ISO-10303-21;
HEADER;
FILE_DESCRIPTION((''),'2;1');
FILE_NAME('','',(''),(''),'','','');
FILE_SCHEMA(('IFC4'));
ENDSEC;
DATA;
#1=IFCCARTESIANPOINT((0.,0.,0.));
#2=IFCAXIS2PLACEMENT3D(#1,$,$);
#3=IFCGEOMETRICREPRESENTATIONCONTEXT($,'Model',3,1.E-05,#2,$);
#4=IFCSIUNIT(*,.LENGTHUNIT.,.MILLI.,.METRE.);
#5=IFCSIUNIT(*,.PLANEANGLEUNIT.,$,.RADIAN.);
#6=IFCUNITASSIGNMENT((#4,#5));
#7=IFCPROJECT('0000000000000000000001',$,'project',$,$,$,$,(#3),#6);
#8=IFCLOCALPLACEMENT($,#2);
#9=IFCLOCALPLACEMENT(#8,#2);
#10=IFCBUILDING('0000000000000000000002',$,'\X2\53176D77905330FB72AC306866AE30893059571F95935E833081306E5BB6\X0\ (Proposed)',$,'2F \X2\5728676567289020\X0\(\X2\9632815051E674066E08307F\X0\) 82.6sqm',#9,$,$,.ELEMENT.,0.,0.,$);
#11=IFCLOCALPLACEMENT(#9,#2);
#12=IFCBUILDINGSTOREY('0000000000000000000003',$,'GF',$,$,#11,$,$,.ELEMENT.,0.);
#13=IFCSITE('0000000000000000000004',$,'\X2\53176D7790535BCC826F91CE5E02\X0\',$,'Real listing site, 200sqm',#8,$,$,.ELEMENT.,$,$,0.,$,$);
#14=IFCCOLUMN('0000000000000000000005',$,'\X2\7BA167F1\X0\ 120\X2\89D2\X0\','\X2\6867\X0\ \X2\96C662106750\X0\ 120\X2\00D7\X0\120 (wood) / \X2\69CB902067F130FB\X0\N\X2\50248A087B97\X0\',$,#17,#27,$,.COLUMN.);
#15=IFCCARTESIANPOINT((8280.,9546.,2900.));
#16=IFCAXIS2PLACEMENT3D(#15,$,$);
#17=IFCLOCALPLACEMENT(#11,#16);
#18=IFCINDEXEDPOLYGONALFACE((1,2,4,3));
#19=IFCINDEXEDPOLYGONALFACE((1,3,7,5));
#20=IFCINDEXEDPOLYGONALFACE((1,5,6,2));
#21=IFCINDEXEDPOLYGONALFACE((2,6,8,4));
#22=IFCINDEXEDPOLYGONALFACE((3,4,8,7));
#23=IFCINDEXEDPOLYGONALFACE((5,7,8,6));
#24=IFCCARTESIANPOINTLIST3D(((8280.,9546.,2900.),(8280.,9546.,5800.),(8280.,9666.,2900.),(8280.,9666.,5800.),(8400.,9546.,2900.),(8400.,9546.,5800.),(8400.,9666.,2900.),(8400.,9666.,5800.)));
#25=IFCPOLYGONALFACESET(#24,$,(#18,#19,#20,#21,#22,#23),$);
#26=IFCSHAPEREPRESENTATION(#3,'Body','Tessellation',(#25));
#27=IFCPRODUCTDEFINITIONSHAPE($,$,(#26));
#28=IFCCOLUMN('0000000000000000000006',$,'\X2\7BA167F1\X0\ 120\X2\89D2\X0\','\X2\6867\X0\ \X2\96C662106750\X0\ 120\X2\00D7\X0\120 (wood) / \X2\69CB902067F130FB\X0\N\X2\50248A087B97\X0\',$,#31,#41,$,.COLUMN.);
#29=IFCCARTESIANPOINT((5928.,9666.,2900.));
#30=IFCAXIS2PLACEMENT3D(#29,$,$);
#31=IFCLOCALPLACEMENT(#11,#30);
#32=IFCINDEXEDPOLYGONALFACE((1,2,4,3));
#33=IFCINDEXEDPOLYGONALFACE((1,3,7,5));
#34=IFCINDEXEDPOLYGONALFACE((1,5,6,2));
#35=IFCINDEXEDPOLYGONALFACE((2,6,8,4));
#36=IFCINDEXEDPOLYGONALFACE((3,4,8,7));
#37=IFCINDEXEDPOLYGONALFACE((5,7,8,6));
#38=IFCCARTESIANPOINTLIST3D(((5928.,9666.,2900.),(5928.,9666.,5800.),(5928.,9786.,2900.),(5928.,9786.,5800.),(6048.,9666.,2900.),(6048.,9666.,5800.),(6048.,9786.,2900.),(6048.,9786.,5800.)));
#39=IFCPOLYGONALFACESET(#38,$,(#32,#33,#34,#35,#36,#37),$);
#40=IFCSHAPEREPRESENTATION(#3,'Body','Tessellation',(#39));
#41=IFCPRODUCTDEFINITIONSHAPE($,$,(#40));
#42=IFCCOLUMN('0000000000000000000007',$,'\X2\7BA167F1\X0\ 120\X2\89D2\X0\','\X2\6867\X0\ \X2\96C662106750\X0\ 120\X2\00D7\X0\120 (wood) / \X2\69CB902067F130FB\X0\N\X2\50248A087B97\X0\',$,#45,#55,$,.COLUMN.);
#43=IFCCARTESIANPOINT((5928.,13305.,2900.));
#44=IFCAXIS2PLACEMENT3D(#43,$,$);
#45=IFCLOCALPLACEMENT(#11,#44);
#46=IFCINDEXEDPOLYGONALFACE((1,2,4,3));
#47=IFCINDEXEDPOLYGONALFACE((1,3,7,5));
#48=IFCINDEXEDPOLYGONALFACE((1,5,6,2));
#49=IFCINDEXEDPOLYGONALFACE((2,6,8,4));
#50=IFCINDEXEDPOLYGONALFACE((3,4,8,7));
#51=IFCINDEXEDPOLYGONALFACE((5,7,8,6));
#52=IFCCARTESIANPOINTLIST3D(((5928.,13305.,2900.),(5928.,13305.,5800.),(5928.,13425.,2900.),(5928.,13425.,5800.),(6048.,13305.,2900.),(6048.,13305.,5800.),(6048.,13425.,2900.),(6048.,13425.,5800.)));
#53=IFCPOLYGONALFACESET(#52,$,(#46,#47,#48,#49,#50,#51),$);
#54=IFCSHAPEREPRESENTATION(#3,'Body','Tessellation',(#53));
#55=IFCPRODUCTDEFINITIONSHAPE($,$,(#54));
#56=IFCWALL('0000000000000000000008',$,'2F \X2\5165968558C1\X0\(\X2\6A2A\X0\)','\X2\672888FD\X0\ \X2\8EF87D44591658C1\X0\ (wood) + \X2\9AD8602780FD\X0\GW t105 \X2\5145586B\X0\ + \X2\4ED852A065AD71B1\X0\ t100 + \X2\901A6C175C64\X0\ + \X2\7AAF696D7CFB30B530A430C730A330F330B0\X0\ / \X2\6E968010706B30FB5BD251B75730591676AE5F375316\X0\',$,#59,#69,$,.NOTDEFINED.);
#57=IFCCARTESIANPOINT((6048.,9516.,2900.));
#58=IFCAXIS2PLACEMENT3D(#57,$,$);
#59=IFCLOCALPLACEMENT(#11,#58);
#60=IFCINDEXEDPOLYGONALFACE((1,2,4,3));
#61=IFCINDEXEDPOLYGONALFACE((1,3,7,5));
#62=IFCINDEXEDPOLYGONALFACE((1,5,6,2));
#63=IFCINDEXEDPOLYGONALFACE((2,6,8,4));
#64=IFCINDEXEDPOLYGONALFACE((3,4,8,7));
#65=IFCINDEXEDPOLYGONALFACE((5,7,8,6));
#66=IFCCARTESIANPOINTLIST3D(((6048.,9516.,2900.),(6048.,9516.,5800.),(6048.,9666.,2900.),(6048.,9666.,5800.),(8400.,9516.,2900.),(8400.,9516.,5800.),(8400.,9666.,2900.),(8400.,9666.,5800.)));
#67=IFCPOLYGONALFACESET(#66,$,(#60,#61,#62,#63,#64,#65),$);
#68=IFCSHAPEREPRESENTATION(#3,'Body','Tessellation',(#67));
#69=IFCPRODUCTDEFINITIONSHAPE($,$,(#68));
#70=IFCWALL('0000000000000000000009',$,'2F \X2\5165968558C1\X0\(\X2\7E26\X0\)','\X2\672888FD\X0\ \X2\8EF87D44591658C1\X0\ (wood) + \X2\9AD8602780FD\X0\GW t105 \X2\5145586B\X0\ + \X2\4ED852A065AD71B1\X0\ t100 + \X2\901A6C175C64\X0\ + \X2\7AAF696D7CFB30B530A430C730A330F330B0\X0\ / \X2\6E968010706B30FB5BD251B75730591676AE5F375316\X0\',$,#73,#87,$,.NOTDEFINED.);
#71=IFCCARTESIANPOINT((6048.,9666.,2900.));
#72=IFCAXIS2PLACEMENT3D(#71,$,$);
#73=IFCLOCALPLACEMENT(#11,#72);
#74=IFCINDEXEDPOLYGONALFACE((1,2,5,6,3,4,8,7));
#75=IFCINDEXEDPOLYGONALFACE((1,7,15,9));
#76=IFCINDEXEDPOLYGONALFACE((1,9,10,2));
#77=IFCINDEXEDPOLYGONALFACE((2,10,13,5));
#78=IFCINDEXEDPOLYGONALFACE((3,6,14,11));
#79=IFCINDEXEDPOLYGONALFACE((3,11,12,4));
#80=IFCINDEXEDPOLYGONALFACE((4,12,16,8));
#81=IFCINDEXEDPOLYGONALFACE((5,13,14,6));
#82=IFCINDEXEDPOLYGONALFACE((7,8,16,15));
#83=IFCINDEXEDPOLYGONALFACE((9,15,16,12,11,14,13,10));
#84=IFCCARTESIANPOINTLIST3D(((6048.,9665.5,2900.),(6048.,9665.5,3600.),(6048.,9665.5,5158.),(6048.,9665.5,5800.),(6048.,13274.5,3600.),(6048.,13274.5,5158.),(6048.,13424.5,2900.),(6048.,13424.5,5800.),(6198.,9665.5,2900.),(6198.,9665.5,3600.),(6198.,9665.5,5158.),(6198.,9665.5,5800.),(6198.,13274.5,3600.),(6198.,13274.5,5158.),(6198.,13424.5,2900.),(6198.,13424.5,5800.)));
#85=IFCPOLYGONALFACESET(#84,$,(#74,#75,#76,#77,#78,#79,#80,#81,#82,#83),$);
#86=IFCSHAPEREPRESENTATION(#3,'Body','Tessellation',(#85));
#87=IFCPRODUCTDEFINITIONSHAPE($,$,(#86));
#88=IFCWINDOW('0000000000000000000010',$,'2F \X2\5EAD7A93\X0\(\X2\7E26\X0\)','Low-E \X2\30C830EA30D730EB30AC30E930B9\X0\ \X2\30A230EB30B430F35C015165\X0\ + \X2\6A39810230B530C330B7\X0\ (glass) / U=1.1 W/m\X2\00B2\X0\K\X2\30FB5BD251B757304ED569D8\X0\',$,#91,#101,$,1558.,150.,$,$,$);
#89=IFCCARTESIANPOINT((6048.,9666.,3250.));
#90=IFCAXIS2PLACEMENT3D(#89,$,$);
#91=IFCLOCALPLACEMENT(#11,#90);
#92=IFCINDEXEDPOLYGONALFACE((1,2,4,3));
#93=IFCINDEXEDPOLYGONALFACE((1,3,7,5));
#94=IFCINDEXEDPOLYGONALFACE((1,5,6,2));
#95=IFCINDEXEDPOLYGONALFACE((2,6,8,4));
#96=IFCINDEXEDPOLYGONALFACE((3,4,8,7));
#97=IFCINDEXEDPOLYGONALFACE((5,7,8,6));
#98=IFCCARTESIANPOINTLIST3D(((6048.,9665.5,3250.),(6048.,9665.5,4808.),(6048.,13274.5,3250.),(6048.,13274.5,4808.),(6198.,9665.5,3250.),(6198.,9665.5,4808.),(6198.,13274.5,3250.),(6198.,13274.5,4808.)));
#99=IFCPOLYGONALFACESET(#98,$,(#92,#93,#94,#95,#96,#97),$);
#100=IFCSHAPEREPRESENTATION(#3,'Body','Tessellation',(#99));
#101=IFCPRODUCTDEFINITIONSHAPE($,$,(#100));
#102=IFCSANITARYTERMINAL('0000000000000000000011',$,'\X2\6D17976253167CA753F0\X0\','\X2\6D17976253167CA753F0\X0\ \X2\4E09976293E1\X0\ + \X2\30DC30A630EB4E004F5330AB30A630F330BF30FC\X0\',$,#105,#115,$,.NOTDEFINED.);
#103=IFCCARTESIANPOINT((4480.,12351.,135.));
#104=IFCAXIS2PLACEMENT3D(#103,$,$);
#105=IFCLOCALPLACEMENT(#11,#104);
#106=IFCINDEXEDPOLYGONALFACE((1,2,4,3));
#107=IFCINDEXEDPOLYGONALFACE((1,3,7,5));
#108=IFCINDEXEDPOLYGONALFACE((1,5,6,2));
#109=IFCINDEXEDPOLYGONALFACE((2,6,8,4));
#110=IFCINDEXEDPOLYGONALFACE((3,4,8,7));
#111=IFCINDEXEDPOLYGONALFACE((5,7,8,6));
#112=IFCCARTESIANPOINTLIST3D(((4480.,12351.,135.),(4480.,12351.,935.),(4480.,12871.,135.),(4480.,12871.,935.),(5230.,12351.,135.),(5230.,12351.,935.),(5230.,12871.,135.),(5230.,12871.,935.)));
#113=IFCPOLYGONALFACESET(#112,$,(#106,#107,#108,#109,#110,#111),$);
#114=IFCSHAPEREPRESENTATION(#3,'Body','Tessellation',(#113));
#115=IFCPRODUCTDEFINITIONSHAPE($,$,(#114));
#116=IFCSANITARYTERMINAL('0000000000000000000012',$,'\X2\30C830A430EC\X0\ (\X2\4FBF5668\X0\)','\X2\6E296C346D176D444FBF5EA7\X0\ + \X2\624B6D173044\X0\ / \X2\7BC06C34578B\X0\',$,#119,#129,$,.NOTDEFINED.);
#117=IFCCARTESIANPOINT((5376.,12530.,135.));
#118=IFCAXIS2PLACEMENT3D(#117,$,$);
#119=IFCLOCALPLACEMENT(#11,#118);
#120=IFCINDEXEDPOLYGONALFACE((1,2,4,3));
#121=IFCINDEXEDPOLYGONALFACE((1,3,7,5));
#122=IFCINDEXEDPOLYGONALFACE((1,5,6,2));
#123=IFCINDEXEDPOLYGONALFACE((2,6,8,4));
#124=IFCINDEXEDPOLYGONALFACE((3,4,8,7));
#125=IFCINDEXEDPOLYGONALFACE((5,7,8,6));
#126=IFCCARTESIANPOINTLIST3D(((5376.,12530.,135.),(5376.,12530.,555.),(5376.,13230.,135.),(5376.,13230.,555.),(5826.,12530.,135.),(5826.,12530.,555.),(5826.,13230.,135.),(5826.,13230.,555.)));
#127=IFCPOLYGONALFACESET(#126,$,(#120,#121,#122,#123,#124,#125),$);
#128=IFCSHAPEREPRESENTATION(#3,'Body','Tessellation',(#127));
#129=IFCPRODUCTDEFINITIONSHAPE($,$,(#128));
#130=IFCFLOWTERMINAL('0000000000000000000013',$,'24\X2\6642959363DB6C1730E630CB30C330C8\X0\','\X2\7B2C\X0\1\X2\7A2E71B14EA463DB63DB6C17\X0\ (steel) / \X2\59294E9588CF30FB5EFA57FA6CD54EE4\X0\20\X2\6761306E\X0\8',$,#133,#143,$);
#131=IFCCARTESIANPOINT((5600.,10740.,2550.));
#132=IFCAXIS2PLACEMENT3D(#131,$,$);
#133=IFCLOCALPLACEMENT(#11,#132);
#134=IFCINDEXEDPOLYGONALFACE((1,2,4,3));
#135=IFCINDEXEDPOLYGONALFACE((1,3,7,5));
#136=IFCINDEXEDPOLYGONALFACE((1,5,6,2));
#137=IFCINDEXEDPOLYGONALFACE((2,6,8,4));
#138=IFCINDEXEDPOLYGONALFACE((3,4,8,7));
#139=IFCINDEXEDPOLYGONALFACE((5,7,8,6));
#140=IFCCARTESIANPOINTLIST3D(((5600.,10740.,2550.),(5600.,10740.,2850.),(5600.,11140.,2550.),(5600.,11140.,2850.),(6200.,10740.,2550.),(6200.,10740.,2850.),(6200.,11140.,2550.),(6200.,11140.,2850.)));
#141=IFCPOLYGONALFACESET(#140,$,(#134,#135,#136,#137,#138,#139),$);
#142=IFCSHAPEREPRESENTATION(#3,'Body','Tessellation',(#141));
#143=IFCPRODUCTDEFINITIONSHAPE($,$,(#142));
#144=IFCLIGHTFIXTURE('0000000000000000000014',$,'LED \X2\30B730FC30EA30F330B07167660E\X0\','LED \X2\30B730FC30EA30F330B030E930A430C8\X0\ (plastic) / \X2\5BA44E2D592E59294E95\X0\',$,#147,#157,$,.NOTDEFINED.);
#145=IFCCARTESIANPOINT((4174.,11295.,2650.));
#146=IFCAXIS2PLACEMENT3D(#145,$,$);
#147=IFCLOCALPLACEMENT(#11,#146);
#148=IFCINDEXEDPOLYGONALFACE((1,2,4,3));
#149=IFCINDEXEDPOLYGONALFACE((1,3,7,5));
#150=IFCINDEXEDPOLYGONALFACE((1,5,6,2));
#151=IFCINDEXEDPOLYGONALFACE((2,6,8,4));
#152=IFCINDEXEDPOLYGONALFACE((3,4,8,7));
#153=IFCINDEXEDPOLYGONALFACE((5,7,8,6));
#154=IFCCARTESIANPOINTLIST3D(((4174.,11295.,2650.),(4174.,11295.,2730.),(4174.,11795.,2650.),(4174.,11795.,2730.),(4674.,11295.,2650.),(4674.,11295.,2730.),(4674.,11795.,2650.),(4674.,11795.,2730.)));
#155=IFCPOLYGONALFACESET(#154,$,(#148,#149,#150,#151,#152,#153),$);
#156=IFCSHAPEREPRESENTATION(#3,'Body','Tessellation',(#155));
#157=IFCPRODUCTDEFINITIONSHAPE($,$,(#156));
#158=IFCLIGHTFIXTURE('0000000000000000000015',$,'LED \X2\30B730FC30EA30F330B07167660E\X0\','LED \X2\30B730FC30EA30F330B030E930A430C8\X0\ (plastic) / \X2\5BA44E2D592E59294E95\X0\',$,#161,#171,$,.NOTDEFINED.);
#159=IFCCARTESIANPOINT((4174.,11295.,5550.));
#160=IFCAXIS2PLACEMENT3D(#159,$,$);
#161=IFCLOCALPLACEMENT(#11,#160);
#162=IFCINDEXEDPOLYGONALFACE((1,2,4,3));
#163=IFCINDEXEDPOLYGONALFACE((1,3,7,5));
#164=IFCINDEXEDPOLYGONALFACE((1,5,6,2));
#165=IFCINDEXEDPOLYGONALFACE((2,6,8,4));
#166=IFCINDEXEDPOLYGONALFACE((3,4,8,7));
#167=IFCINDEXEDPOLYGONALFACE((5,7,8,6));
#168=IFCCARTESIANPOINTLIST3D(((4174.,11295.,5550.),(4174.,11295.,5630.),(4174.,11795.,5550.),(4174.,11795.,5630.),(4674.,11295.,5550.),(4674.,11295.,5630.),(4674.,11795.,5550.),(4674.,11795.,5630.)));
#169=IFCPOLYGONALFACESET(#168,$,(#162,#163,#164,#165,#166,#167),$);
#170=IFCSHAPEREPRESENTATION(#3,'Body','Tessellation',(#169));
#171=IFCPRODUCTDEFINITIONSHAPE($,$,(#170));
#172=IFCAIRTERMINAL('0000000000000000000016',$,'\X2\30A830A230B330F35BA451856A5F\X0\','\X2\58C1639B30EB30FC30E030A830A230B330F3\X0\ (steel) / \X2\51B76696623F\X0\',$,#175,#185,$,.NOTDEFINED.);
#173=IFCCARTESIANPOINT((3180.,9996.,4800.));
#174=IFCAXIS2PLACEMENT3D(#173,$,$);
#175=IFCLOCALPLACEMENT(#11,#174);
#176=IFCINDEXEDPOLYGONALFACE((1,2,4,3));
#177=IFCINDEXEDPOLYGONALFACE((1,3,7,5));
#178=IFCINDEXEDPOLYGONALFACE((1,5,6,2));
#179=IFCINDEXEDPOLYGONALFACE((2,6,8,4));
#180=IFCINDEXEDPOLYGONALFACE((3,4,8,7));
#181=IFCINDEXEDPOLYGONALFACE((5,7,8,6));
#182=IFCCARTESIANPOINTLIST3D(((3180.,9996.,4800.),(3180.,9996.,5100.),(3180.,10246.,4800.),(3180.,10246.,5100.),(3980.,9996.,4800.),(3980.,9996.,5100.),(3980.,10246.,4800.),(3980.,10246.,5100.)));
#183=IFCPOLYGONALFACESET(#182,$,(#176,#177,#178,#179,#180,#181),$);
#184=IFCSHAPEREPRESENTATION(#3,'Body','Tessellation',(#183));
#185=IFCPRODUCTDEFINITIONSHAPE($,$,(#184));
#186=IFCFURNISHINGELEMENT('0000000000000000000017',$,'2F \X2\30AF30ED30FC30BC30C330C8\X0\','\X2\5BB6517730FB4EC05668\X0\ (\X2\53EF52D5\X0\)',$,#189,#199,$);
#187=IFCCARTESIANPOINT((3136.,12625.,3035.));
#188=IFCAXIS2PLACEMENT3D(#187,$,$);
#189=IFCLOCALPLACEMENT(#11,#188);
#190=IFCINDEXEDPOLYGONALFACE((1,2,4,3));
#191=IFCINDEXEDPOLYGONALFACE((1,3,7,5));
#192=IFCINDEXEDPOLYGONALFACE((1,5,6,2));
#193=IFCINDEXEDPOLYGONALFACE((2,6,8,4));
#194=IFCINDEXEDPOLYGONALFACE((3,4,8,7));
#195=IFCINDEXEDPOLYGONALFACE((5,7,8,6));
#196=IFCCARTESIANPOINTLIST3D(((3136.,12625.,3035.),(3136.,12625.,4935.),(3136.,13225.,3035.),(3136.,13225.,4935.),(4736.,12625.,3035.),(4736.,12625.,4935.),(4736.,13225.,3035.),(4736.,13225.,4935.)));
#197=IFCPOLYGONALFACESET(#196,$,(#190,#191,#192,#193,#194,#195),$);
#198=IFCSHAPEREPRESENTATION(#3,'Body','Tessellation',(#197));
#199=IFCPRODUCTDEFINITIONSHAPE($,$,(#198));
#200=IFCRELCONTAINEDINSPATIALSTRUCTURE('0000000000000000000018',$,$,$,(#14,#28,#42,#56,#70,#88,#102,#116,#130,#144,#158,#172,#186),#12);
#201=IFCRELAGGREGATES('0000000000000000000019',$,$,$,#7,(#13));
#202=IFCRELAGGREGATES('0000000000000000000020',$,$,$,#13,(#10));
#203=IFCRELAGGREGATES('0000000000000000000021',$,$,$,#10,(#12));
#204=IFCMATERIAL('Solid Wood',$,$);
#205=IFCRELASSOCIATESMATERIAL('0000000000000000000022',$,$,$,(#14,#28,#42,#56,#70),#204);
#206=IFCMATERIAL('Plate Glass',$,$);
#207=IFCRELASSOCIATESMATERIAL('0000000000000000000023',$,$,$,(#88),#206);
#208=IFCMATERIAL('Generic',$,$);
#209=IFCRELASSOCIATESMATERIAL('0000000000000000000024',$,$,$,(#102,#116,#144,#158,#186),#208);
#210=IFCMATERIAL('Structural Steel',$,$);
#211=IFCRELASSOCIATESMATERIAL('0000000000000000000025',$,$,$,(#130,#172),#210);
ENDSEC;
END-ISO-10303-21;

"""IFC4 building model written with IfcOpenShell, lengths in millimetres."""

from ifc_helpers import new_model, si_unit, frame, frame_2d, origin, place, context, project, spatial, rectangle, extrude, material, element, fill, save


model = new_model("IFC4")

# Units and contexts
model_context = context("Model", 3, precision=1e-05, world=origin())
ifc_project = project(units=[si_unit("LENGTHUNIT", "METRE", prefix="MILLI"), si_unit("PLANEANGLEUNIT", "RADIAN")], contexts=[model_context])

# Site, building, storey
site_placement = place(None, origin())
site = spatial("IfcSite", under=ifc_project, at=site_placement, Name="北海道富良野市", ObjectType="Real listing site, 200sqm", CompositionType="ELEMENT", RefElevation=0.0)
building_placement = place(site_placement, origin())
building = spatial("IfcBuilding", under=site, at=building_placement, Name="北海道・犬と暮らす土間広めの家 (Proposed)", ObjectType="2F 在来木造(防腐処理済み) 82.6sqm", CompositionType="ELEMENT", ElevationOfRefHeight=0.0, ElevationOfTerrain=0.0)
storey_placement = place(building_placement, origin())
storey = spatial("IfcBuildingStorey", under=building, at=storey_placement, Name="GF", CompositionType="ELEMENT", Elevation=0.0)

# Columns
ifc_material_1 = material(Name="Solid Wood")
column_1_placement = place(storey_placement, frame((8280.0, 9546.0, 2900.0)))
element("IfcColumn", 1, at=column_1_placement, inside=storey, material=ifc_material_1, Name="管柱 120角", Description="桧 集成材 120×120 (wood) / 構造柱・N値計算", PredefinedType="COLUMN", context=model_context, shape_type="SweptSolid", body=[
    extrude(rectangle(XDim=120.0, YDim=120.0, at=frame_2d((60.0, 60.0))), frame((8280.0, 9546.0, 2900.0)), (0.0, 0.0, 1.0), 2900.0),
])
column_2_placement = place(storey_placement, frame((5928.0, 9666.0, 2900.0)))
element("IfcColumn", 2, at=column_2_placement, inside=storey, material=ifc_material_1, Name="管柱 120角", Description="桧 集成材 120×120 (wood) / 構造柱・N値計算", PredefinedType="COLUMN", context=model_context, shape_type="SweptSolid", body=[
    extrude(rectangle(XDim=120.0, YDim=120.0, at=frame_2d((60.0, 60.0))), frame((5928.0, 9666.0, 2900.0)), (0.0, 0.0, 1.0), 2900.0),
])
column_3_placement = place(storey_placement, frame((5928.0, 13305.0, 2900.0)))
element("IfcColumn", 3, at=column_3_placement, inside=storey, material=ifc_material_1, Name="管柱 120角", Description="桧 集成材 120×120 (wood) / 構造柱・N値計算", PredefinedType="COLUMN", context=model_context, shape_type="SweptSolid", body=[
    extrude(rectangle(XDim=120.0, YDim=120.0, at=frame_2d((60.0, 60.0))), frame((5928.0, 13305.0, 2900.0)), (0.0, 0.0, 1.0), 2900.0),
])

# Wall
wall_1_placement = place(storey_placement, frame((6048.0, 9516.0, 2900.0)))
element("IfcWall", 4, at=wall_1_placement, inside=storey, material=ifc_material_1, Name="2F 入隅壁(横)", Description="木製 軸組外壁 (wood) + 高性能GW t105 充填 + 付加断熱 t100 + 通気層 + 窯業系サイディング / 準耐火・寒冷地外皮強化", PredefinedType="NOTDEFINED", context=model_context, shape_type="SweptSolid", body=[
    extrude(rectangle(XDim=2352.0, YDim=150.0, at=frame_2d((1176.0, 75.0))), frame((6048.0, 9516.0, 2900.0)), (0.0, 0.0, 1.0), 2900.0),
])

# Wall, opening, window
wall_2_placement = place(storey_placement, frame((6048.0, 9666.0, 2900.0)))
wall_2 = element("IfcWall", 5, at=wall_2_placement, inside=storey, material=ifc_material_1, Name="2F 入隅壁(縦)", Description="木製 軸組外壁 (wood) + 高性能GW t105 充填 + 付加断熱 t100 + 通気層 + 窯業系サイディング / 準耐火・寒冷地外皮強化", PredefinedType="NOTDEFINED", context=model_context, shape_type="SweptSolid", body=[
    extrude(rectangle(XDim=150.0, YDim=3759.0, at=frame_2d((75.0, 1879.0))), frame((6048.0, 9666.0, 2900.0)), (0.0, 0.0, 1.0), 2900.0),
])
opening_placement = place(storey_placement, frame((6048.0, 9666.0, 3250.0)))
opening = element("IfcOpeningElement", 6, at=opening_placement, cuts=wall_2, PredefinedType="NOTDEFINED", context=model_context, shape_type="SweptSolid", body=[
    extrude(rectangle(XDim=150.0, YDim=3609.0, at=frame_2d((75.0, 1804.0))), frame((6048.0, 9666.0, 3250.0)), (0.0, 0.0, 1.0), 1558.0),
])
ifc_material_2 = material(Name="Plate Glass")
window_placement = place(storey_placement, frame((6048.0, 9666.0, 3250.0)))
window = element("IfcWindow", 7, at=window_placement, inside=storey, material=ifc_material_2, Name="2F 庭窓(縦)", Description="Low-E トリプルガラス アルゴン封入 + 樹脂サッシ (glass) / U=1.1 W/m²K・寒冷地仕様", OverallHeight=1558.0, OverallWidth=150.0, context=model_context, shape_type="SweptSolid", body=[
    extrude(rectangle(XDim=150.0, YDim=3609.0, at=frame_2d((75.0, 1804.0))), frame((6048.0, 9666.0, 3250.0)), (0.0, 0.0, 1.0), 1558.0),
])
fill(opening, window)

# Sanitary terminals
ifc_material_3 = material(Name="Generic")
sanitary_terminal_1_placement = place(storey_placement, frame((4480.0, 12351.0, 135.0)))
element("IfcSanitaryTerminal", 8, at=sanitary_terminal_1_placement, inside=storey, material=ifc_material_3, Name="洗面化粧台", Description="洗面化粧台 三面鏡 + ボウル一体カウンター", PredefinedType="NOTDEFINED", context=model_context, shape_type="SweptSolid", body=[
    extrude(rectangle(XDim=750.0, YDim=520.0, at=frame_2d((375.0, 260.0))), frame((4480.0, 12351.0, 135.0)), (0.0, 0.0, 1.0), 800.0),
])
sanitary_terminal_2_placement = place(storey_placement, frame((5376.0, 12530.0, 135.0)))
element("IfcSanitaryTerminal", 9, at=sanitary_terminal_2_placement, inside=storey, material=ifc_material_3, Name="トイレ (便器)", Description="温水洗浄便座 + 手洗い / 節水型", PredefinedType="NOTDEFINED", context=model_context, shape_type="SweptSolid", body=[
    extrude(rectangle(XDim=450.0, YDim=700.0, at=frame_2d((225.0, 350.0))), frame((5376.0, 12530.0, 135.0)), (0.0, 0.0, 1.0), 420.0),
])

# Flow terminal
ifc_material_4 = material(Name="Structural Steel")
flow_terminal_placement = place(storey_placement, frame((5600.0, 10740.0, 2550.0)))
element("IfcFlowTerminal", 10, at=flow_terminal_placement, inside=storey, material=ifc_material_4, Name="24時間換気ユニット", Description="第1種熱交換換気 (steel) / 天井裏・建基法令20条の8", context=model_context, shape_type="SweptSolid", body=[
    extrude(rectangle(XDim=600.0, YDim=400.0, at=frame_2d((300.0, 200.0))), frame((5600.0, 10740.0, 2550.0)), (0.0, 0.0, 1.0), 300.0),
])

# Light fixtures
light_fixture_1_placement = place(storey_placement, frame((4174.0, 11295.0, 2650.0)))
element("IfcLightFixture", 11, at=light_fixture_1_placement, inside=storey, material=ifc_material_3, Name="LED シーリング照明", Description="LED シーリングライト (plastic) / 室中央天井", PredefinedType="NOTDEFINED", context=model_context, shape_type="SweptSolid", body=[
    extrude(rectangle(XDim=500.0, YDim=500.0, at=frame_2d((250.0, 250.0))), frame((4174.0, 11295.0, 2650.0)), (0.0, 0.0, 1.0), 80.0),
])
light_fixture_2_placement = place(storey_placement, frame((4174.0, 11295.0, 5550.0)))
element("IfcLightFixture", 12, at=light_fixture_2_placement, inside=storey, material=ifc_material_3, Name="LED シーリング照明", Description="LED シーリングライト (plastic) / 室中央天井", PredefinedType="NOTDEFINED", context=model_context, shape_type="SweptSolid", body=[
    extrude(rectangle(XDim=500.0, YDim=500.0, at=frame_2d((250.0, 250.0))), frame((4174.0, 11295.0, 5550.0)), (0.0, 0.0, 1.0), 80.0),
])

# Air terminal
air_terminal_placement = place(storey_placement, frame((3180.0, 9996.0, 4800.0)))
element("IfcAirTerminal", 13, at=air_terminal_placement, inside=storey, material=ifc_material_4, Name="エアコン室内機", Description="壁掛ルームエアコン (steel) / 冷暖房", PredefinedType="NOTDEFINED", context=model_context, shape_type="SweptSolid", body=[
    extrude(rectangle(XDim=800.0, YDim=250.0, at=frame_2d((400.0, 125.0))), frame((3180.0, 9996.0, 4800.0)), (0.0, 0.0, 1.0), 300.0),
])

# Furnishing element
furnishing_1_placement = place(storey_placement, frame((3136.0, 12625.0, 3035.0)))
element("IfcFurnishingElement", 14, at=furnishing_1_placement, inside=storey, material=ifc_material_3, Name="2F クローゼット", Description="家具・什器 (可動)", context=model_context, shape_type="SweptSolid", body=[
    extrude(rectangle(XDim=1600.0, YDim=600.0, at=frame_2d((800.0, 300.0))), frame((3136.0, 12625.0, 3035.0)), (0.0, 0.0, 1.0), 1900.0),
])

save(model, "model.ifc")
